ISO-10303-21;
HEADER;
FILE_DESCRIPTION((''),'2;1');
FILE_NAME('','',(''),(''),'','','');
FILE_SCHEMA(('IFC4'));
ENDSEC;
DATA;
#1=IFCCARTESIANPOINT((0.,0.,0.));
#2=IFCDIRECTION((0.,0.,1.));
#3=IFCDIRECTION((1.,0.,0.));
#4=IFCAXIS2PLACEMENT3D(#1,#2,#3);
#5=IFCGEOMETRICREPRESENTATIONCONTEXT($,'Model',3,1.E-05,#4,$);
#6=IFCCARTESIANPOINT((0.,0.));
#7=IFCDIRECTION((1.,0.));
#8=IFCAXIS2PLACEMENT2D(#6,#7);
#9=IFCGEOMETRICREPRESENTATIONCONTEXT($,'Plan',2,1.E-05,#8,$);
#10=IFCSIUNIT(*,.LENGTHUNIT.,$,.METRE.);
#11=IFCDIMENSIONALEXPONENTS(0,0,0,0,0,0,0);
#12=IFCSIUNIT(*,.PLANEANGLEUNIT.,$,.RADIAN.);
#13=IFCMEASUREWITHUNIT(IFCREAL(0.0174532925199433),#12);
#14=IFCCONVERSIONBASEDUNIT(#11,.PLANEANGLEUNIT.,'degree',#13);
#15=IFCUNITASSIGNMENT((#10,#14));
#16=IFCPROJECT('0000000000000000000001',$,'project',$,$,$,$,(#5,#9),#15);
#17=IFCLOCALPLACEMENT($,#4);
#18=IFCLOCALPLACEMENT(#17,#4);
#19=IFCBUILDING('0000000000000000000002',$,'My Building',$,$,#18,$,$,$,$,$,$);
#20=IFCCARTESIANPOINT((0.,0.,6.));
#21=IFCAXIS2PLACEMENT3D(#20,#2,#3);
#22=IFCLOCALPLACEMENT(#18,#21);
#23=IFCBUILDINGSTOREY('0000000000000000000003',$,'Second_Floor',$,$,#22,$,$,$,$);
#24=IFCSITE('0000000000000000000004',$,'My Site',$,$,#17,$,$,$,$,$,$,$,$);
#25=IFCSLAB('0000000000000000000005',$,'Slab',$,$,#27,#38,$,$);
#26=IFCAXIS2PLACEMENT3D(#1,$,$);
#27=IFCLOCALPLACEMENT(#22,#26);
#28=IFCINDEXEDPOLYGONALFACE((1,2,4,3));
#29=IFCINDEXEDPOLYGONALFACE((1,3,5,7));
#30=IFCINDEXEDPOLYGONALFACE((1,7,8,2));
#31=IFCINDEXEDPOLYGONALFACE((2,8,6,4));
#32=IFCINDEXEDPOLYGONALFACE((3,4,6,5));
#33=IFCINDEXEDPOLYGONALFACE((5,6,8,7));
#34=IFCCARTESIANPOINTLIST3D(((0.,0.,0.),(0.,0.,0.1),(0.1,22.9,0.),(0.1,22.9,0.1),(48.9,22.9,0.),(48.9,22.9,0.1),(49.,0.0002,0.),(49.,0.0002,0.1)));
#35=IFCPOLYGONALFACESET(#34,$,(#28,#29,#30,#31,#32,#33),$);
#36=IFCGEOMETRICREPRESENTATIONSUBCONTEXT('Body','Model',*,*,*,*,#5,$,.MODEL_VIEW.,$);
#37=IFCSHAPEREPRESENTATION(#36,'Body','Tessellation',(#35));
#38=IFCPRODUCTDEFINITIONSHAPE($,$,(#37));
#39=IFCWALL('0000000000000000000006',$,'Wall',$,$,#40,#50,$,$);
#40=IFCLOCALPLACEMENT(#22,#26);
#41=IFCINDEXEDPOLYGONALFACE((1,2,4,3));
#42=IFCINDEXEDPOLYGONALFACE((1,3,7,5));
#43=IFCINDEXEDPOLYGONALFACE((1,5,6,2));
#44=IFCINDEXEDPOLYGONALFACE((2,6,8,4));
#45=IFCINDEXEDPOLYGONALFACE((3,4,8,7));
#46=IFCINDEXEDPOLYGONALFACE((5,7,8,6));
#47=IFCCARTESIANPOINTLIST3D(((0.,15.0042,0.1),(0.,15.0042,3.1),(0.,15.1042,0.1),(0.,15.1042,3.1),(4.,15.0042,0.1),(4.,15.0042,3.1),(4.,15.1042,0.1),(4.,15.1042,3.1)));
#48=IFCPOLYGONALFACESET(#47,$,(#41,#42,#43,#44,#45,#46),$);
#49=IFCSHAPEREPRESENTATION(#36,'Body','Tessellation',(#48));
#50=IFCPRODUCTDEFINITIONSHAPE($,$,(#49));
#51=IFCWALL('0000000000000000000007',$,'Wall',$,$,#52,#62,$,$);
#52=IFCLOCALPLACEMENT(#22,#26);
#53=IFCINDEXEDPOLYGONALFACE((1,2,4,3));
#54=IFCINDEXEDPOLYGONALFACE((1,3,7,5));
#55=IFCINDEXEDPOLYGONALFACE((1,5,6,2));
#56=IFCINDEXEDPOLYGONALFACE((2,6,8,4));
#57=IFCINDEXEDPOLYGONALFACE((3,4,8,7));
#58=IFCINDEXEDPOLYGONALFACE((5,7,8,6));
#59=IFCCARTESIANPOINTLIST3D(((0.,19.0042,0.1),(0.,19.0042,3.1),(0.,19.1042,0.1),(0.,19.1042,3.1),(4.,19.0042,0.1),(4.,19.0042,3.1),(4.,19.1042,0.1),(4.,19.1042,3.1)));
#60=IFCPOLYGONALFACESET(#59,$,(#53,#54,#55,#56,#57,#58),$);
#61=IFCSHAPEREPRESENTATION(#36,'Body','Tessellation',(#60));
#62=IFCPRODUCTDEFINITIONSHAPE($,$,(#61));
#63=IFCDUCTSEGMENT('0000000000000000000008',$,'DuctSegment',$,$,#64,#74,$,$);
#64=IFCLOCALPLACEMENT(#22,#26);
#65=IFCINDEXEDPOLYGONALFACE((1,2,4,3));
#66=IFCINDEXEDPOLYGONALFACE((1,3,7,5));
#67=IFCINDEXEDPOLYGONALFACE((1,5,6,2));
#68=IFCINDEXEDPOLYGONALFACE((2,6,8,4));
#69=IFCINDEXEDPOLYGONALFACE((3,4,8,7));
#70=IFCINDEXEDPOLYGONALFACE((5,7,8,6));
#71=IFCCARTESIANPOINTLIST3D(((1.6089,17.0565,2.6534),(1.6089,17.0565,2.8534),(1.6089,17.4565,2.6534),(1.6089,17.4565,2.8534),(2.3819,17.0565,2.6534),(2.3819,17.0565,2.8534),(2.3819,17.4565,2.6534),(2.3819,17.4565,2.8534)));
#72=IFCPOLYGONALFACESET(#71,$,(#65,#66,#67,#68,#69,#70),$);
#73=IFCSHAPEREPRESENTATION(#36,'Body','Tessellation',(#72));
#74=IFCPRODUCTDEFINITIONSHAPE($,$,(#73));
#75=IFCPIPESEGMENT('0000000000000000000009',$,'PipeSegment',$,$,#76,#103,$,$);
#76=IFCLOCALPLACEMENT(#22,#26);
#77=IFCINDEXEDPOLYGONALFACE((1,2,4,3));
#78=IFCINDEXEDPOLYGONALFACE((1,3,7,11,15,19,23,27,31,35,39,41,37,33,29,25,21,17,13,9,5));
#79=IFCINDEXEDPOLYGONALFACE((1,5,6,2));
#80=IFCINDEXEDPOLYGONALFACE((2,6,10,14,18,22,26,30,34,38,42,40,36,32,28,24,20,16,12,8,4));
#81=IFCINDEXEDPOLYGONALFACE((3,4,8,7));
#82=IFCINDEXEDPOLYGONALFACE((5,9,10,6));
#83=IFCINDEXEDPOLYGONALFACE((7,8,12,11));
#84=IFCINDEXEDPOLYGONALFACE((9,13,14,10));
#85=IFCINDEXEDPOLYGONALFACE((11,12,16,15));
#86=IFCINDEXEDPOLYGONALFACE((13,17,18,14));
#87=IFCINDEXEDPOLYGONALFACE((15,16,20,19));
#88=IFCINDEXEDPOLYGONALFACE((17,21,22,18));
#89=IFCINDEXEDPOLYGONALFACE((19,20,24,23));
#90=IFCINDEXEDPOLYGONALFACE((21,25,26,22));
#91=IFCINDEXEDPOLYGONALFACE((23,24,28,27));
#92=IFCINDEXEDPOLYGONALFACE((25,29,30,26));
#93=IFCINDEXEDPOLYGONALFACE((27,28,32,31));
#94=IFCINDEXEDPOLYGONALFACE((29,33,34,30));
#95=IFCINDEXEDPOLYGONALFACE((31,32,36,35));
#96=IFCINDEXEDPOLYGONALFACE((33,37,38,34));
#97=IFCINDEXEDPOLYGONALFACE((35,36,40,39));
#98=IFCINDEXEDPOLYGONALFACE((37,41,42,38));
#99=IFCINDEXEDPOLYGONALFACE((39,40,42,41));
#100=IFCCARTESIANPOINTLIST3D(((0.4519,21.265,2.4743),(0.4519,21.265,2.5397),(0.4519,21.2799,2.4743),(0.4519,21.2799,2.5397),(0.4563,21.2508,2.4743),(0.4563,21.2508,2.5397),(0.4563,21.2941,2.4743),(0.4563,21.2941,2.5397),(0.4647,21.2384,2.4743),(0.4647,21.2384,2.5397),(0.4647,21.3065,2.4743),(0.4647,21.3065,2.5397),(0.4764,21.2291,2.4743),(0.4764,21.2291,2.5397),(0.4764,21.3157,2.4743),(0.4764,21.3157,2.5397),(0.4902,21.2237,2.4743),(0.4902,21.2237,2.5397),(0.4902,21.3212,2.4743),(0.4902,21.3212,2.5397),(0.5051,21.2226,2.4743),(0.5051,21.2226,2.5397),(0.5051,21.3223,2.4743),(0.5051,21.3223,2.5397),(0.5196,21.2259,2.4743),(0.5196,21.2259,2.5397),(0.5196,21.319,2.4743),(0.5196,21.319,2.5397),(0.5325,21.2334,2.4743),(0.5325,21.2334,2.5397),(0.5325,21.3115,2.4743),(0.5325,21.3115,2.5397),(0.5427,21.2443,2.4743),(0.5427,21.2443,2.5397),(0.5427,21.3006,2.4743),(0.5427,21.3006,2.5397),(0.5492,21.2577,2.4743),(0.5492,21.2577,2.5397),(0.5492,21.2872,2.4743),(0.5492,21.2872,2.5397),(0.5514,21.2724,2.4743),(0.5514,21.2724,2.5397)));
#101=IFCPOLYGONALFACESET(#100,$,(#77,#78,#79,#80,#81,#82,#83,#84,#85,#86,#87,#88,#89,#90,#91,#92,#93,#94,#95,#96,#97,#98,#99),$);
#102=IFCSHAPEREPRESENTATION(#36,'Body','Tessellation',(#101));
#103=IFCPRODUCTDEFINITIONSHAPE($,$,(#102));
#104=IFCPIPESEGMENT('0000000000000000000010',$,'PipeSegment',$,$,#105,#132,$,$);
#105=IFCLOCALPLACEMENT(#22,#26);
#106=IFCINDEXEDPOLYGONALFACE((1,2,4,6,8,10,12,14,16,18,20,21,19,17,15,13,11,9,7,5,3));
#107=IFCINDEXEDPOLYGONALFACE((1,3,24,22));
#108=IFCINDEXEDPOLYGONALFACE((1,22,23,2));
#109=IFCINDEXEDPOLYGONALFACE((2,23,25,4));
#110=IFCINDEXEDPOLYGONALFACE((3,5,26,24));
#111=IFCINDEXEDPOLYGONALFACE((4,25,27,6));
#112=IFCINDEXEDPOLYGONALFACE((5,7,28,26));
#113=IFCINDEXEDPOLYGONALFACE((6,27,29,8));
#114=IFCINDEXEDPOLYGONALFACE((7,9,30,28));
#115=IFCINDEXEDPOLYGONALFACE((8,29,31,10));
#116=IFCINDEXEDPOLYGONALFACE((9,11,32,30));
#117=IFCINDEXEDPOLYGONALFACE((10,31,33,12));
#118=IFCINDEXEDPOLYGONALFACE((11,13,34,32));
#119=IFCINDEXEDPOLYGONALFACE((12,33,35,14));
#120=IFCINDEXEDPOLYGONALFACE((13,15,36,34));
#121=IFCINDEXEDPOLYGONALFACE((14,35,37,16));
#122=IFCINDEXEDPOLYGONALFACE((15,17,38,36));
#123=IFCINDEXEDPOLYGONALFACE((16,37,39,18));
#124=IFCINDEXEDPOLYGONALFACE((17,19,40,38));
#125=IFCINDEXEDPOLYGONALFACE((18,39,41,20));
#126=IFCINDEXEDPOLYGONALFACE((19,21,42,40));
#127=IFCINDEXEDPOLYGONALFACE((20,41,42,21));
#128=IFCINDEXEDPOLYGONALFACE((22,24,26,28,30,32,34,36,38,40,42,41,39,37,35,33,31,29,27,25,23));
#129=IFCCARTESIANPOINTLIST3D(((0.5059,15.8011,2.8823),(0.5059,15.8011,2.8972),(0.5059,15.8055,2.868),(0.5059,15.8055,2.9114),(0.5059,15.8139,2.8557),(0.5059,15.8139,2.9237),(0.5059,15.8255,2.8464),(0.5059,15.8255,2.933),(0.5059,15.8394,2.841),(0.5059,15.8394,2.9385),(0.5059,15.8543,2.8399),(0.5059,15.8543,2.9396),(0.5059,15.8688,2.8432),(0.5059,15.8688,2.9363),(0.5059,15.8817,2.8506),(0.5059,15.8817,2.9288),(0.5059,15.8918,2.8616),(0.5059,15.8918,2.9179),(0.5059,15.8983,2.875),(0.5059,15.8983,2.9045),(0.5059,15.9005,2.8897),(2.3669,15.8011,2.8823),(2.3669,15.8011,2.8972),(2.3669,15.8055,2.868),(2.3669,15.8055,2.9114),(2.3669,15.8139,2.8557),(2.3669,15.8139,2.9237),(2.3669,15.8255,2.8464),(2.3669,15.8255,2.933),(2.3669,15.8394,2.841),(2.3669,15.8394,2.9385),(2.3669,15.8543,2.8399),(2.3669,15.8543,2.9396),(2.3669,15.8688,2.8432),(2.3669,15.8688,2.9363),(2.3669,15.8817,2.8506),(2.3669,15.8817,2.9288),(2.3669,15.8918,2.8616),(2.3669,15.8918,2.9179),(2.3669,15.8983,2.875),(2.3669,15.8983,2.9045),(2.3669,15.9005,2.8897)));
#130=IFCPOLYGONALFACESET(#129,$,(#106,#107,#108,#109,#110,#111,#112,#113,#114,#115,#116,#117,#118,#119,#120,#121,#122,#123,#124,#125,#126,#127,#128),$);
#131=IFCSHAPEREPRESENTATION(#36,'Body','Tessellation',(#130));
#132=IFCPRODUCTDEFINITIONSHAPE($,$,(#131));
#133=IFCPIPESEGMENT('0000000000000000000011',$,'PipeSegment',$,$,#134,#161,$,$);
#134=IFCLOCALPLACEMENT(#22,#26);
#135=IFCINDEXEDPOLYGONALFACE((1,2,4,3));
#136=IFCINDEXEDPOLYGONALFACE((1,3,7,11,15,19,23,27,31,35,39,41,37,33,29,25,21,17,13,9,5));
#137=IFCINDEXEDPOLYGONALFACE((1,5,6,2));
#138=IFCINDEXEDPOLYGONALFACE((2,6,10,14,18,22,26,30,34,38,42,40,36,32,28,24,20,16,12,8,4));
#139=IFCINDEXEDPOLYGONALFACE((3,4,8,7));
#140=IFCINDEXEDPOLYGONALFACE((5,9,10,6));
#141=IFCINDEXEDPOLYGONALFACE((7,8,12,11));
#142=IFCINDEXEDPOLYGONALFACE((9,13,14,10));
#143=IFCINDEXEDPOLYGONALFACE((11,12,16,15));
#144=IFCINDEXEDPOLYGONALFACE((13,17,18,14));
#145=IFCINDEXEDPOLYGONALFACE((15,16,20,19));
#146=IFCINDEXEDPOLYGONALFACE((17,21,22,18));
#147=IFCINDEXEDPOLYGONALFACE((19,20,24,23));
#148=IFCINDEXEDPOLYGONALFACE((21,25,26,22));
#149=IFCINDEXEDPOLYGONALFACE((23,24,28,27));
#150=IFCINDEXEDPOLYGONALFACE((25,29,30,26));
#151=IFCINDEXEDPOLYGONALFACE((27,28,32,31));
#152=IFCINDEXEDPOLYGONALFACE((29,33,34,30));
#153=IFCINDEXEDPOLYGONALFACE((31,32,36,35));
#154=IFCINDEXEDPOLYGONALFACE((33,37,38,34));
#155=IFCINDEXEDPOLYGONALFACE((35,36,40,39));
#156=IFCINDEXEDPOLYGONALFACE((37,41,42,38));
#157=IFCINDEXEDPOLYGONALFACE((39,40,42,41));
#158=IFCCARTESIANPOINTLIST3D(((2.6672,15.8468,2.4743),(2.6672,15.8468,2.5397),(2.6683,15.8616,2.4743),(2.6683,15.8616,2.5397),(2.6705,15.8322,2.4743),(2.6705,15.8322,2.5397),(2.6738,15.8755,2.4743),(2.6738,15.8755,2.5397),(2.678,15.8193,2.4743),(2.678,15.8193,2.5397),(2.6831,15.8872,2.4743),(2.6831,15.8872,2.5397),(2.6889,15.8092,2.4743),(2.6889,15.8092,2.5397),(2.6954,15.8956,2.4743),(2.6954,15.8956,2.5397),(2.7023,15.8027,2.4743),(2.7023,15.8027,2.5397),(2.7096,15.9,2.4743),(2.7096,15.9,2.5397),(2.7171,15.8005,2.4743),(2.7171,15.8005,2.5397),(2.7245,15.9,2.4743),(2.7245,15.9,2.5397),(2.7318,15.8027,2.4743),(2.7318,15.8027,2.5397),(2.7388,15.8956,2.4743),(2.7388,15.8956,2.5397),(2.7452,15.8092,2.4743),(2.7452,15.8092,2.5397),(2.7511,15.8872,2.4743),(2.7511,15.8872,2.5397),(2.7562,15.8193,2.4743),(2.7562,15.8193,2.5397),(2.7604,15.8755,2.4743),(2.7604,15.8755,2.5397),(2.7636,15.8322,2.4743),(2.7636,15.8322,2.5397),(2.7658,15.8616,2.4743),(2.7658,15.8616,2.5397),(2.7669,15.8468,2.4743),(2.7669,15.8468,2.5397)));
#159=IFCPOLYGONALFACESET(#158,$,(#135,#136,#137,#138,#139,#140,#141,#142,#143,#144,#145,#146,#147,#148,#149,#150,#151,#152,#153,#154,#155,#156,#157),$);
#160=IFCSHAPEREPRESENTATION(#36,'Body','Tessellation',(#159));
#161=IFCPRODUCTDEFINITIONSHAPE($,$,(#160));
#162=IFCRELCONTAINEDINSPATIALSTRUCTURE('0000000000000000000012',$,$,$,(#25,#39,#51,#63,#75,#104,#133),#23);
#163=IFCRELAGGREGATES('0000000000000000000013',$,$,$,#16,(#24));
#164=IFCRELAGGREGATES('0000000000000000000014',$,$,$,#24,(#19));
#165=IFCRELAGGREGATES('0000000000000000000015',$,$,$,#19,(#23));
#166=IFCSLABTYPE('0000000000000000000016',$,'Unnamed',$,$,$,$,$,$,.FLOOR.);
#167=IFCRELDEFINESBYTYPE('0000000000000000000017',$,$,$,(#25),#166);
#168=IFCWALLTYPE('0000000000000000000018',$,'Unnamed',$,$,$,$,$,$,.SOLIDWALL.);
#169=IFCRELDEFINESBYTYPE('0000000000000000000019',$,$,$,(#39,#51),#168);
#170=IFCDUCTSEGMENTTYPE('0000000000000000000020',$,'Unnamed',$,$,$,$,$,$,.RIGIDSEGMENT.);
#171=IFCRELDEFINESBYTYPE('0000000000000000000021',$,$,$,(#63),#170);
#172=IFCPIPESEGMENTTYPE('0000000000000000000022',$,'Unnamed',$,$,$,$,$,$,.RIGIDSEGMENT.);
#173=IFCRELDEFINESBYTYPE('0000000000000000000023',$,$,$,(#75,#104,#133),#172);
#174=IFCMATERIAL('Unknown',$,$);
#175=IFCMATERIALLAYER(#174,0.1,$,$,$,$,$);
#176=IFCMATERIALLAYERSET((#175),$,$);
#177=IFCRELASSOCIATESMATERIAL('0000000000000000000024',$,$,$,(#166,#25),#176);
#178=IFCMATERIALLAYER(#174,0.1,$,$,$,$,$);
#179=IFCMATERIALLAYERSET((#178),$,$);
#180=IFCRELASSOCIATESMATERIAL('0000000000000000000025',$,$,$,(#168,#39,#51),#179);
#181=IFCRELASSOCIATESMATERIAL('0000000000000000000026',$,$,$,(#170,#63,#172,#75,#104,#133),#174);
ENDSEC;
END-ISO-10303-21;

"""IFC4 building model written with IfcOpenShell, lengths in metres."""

from ifc_helpers import new_model, entity, si_unit, converted_unit, frame, origin_with_axes, origin_2d_with_axis, place, context, subcontext, project, spatial, line, indexed_curve, rectangle, circle, outline, extrude, material, layer, layer_set, layer_usage, material_profile, profile_set, profile_usage, type_object, element, save


model = new_model("IFC4")

# Units and contexts
model_context = context("Model", 3, precision=1e-05, world=origin_with_axes())
plan_context = context("Plan", 2, precision=1e-05, world=origin_2d_with_axis())
body_context_1 = subcontext(model_context, "Body", "Model", "MODEL_VIEW")
ifc_project = project(units=[si_unit("LENGTHUNIT", "METRE"), converted_unit("PLANEANGLEUNIT", "degree", entity("IfcReal", 0.0174532925199433), si_unit("PLANEANGLEUNIT", "RADIAN"), dimensions=[0, 0, 0, 0, 0, 0, 0])], contexts=[model_context, plan_context])

# Site, building, storey
site_placement = place(None, origin_with_axes())
site = spatial("IfcSite", under=ifc_project, at=site_placement, Name="My Site")
building_placement = place(site_placement, origin_with_axes())
building = spatial("IfcBuilding", under=site, at=building_placement, Name="My Building")
storey_placement = place(building_placement, frame((0.0, 0.0, 6.0), z_axis=(0.0, 0.0, 1.0), x_axis=(1.0, 0.0, 0.0)))
storey = spatial("IfcBuildingStorey", under=building, at=storey_placement, Name="Second_Floor")

# Slab
ifc_material = material(Name="Unknown")
ifc_layer_1 = layer(ifc_material, 0.1)
ifc_layer_set_1 = layer_set([ifc_layer_1])
ifc_layer_usage_1 = layer_usage(ifc_layer_set_1, "AXIS3", "POSITIVE", -0.1)
slab_type = type_object("IfcSlabType", Name="Unnamed", PredefinedType="FLOOR", material=ifc_layer_set_1)
slab_placement = place(storey_placement, frame((0.1, 22.9, 0.1), z_axis=(0.0, 0.0, 1.0), x_axis=(1.0, 0.0, 0.0)))
element("IfcSlab", 1, at=slab_placement, inside=storey, type_object=slab_type, material=ifc_layer_usage_1, Name="Slab", context=body_context_1, shape_type="SweptSolid", body=[
    extrude(outline(indexed_curve([(0.0, 0.0), (48.8, 0.0), (48.9, -22.8998), (-0.1, -22.9), (0.0, 0.0)])), frame((0.0, 0.0, -0.1), z_axis=(0.0, 0.0, 1.0), x_axis=(1.0, 0.0, 0.0)), (0.0, 0.0, 1.0), 0.1),
])

# Shared definitions
ifc_layer_2 = layer(ifc_material, 0.1)
ifc_layer_set_2 = layer_set([ifc_layer_2])
wall_type = type_object("IfcWallType", Name="Unnamed", PredefinedType="SOLIDWALL", material=ifc_layer_set_2)

# Walls
ifc_layer_usage_2 = layer_usage(ifc_layer_set_2, "AXIS2", "POSITIVE", 0.0)
wall_1_placement = place(storey_placement, frame((0.0, 15.0042, 0.1), z_axis=(0.0, 0.0, 1.0), x_axis=(1.0, 0.0, 0.0)))
element("IfcWall", 2, at=wall_1_placement, inside=storey, type_object=wall_type, material=ifc_layer_usage_2, Name="Wall", context=body_context_1, shape_type="SweptSolid", body=[
    extrude(outline(indexed_curve([(0.0, 0.0), (0.0, 0.1), (4.0, 0.1), (4.0, 0.0)], segments=[line(1, 2, 3, 4, 1)])), origin_with_axes(), (0.0, 0.0, 1.0), 3.0),
])
ifc_layer_usage_3 = layer_usage(ifc_layer_set_2, "AXIS2", "POSITIVE", 0.0)
wall_2_placement = place(storey_placement, frame((0.0, 19.0042, 0.1), z_axis=(0.0, 0.0, 1.0), x_axis=(1.0, 0.0, 0.0)))
element("IfcWall", 3, at=wall_2_placement, inside=storey, type_object=wall_type, material=ifc_layer_usage_3, Name="Wall", context=body_context_1, shape_type="SweptSolid", body=[
    extrude(outline(indexed_curve([(0.0, 0.0), (0.0, 0.1), (4.0, 0.1), (4.0, 0.0)], segments=[line(1, 2, 3, 4, 1)])), origin_with_axes(), (0.0, 0.0, 1.0), 3.0),
])

# Duct segment
ifc_material_profile_1 = material_profile(ifc_material, rectangle(XDim=0.4, YDim=0.2))
ifc_profile_set_1 = profile_set([ifc_material_profile_1])
ifc_profile_usage_1 = profile_usage(ifc_profile_set_1, cardinal=5)
duct_segment_type = type_object("IfcDuctSegmentType", Name="Unnamed", PredefinedType="RIGIDSEGMENT", material=ifc_profile_set_1)
duct_segment_placement = place(storey_placement, frame((1.6089, 17.2565, 2.7534), z_axis=(1.0, -0.000001, 0.000001), x_axis=(0.000001, 1.0, 0.0)))
element("IfcDuctSegment", 4, at=duct_segment_placement, inside=storey, type_object=duct_segment_type, material=ifc_profile_usage_1, Name="DuctSegment", context=body_context_1, shape_type="SweptSolid", body=[
    extrude(rectangle(XDim=0.4, YDim=0.2), origin_with_axes(), (0.0, 0.0, 1.0), 0.773),
])

# Pipe segments
ifc_material_profile_2 = material_profile(ifc_material, circle(Radius=0.05))
ifc_profile_set_2 = profile_set([ifc_material_profile_2])
ifc_profile_usage_2 = profile_usage(ifc_profile_set_2, cardinal=5)
pipe_segment_type = type_object("IfcPipeSegmentType", Name="Unnamed", PredefinedType="RIGIDSEGMENT", material=ifc_profile_set_2)
pipe_segment_1_placement = place(storey_placement, frame((0.5014, 21.2724, 2.4743), z_axis=(0.0, 0.0, 1.0), x_axis=(1.0, 0.000001, 0.0)))
element("IfcPipeSegment", 5, at=pipe_segment_1_placement, inside=storey, type_object=pipe_segment_type, material=ifc_profile_usage_2, Name="PipeSegment", context=body_context_1, shape_type="SweptSolid", body=[
    extrude(circle(Radius=0.05), origin_with_axes(), (0.0, 0.0, 1.0), 0.0654),
])
ifc_profile_usage_3 = profile_usage(ifc_profile_set_2, cardinal=5)
pipe_segment_2_placement = place(storey_placement, frame((0.5059, 15.8505, 2.8897), z_axis=(1.0, 0.0, 0.0), x_axis=(0.0, 1.0, 0.0)))
element("IfcPipeSegment", 6, at=pipe_segment_2_placement, inside=storey, type_object=pipe_segment_type, material=ifc_profile_usage_3, Name="PipeSegment", context=body_context_1, shape_type="SweptSolid", body=[
    extrude(circle(Radius=0.05), origin_with_axes(), (0.0, 0.0, 1.0), 1.861),
])
ifc_profile_usage_4 = profile_usage(ifc_profile_set_2, cardinal=5)
pipe_segment_3_placement = place(storey_placement, frame((2.7171, 15.8505, 2.4743), z_axis=(0.0, 0.0, 1.0), x_axis=(0.000001, -1.0, 0.0)))
element("IfcPipeSegment", 7, at=pipe_segment_3_placement, inside=storey, type_object=pipe_segment_type, material=ifc_profile_usage_4, Name="PipeSegment", context=body_context_1, shape_type="SweptSolid", body=[
    extrude(circle(Radius=0.05), origin_with_axes(), (0.0, 0.0, 1.0), 0.0654),
])

save(model, "model.ifc")
